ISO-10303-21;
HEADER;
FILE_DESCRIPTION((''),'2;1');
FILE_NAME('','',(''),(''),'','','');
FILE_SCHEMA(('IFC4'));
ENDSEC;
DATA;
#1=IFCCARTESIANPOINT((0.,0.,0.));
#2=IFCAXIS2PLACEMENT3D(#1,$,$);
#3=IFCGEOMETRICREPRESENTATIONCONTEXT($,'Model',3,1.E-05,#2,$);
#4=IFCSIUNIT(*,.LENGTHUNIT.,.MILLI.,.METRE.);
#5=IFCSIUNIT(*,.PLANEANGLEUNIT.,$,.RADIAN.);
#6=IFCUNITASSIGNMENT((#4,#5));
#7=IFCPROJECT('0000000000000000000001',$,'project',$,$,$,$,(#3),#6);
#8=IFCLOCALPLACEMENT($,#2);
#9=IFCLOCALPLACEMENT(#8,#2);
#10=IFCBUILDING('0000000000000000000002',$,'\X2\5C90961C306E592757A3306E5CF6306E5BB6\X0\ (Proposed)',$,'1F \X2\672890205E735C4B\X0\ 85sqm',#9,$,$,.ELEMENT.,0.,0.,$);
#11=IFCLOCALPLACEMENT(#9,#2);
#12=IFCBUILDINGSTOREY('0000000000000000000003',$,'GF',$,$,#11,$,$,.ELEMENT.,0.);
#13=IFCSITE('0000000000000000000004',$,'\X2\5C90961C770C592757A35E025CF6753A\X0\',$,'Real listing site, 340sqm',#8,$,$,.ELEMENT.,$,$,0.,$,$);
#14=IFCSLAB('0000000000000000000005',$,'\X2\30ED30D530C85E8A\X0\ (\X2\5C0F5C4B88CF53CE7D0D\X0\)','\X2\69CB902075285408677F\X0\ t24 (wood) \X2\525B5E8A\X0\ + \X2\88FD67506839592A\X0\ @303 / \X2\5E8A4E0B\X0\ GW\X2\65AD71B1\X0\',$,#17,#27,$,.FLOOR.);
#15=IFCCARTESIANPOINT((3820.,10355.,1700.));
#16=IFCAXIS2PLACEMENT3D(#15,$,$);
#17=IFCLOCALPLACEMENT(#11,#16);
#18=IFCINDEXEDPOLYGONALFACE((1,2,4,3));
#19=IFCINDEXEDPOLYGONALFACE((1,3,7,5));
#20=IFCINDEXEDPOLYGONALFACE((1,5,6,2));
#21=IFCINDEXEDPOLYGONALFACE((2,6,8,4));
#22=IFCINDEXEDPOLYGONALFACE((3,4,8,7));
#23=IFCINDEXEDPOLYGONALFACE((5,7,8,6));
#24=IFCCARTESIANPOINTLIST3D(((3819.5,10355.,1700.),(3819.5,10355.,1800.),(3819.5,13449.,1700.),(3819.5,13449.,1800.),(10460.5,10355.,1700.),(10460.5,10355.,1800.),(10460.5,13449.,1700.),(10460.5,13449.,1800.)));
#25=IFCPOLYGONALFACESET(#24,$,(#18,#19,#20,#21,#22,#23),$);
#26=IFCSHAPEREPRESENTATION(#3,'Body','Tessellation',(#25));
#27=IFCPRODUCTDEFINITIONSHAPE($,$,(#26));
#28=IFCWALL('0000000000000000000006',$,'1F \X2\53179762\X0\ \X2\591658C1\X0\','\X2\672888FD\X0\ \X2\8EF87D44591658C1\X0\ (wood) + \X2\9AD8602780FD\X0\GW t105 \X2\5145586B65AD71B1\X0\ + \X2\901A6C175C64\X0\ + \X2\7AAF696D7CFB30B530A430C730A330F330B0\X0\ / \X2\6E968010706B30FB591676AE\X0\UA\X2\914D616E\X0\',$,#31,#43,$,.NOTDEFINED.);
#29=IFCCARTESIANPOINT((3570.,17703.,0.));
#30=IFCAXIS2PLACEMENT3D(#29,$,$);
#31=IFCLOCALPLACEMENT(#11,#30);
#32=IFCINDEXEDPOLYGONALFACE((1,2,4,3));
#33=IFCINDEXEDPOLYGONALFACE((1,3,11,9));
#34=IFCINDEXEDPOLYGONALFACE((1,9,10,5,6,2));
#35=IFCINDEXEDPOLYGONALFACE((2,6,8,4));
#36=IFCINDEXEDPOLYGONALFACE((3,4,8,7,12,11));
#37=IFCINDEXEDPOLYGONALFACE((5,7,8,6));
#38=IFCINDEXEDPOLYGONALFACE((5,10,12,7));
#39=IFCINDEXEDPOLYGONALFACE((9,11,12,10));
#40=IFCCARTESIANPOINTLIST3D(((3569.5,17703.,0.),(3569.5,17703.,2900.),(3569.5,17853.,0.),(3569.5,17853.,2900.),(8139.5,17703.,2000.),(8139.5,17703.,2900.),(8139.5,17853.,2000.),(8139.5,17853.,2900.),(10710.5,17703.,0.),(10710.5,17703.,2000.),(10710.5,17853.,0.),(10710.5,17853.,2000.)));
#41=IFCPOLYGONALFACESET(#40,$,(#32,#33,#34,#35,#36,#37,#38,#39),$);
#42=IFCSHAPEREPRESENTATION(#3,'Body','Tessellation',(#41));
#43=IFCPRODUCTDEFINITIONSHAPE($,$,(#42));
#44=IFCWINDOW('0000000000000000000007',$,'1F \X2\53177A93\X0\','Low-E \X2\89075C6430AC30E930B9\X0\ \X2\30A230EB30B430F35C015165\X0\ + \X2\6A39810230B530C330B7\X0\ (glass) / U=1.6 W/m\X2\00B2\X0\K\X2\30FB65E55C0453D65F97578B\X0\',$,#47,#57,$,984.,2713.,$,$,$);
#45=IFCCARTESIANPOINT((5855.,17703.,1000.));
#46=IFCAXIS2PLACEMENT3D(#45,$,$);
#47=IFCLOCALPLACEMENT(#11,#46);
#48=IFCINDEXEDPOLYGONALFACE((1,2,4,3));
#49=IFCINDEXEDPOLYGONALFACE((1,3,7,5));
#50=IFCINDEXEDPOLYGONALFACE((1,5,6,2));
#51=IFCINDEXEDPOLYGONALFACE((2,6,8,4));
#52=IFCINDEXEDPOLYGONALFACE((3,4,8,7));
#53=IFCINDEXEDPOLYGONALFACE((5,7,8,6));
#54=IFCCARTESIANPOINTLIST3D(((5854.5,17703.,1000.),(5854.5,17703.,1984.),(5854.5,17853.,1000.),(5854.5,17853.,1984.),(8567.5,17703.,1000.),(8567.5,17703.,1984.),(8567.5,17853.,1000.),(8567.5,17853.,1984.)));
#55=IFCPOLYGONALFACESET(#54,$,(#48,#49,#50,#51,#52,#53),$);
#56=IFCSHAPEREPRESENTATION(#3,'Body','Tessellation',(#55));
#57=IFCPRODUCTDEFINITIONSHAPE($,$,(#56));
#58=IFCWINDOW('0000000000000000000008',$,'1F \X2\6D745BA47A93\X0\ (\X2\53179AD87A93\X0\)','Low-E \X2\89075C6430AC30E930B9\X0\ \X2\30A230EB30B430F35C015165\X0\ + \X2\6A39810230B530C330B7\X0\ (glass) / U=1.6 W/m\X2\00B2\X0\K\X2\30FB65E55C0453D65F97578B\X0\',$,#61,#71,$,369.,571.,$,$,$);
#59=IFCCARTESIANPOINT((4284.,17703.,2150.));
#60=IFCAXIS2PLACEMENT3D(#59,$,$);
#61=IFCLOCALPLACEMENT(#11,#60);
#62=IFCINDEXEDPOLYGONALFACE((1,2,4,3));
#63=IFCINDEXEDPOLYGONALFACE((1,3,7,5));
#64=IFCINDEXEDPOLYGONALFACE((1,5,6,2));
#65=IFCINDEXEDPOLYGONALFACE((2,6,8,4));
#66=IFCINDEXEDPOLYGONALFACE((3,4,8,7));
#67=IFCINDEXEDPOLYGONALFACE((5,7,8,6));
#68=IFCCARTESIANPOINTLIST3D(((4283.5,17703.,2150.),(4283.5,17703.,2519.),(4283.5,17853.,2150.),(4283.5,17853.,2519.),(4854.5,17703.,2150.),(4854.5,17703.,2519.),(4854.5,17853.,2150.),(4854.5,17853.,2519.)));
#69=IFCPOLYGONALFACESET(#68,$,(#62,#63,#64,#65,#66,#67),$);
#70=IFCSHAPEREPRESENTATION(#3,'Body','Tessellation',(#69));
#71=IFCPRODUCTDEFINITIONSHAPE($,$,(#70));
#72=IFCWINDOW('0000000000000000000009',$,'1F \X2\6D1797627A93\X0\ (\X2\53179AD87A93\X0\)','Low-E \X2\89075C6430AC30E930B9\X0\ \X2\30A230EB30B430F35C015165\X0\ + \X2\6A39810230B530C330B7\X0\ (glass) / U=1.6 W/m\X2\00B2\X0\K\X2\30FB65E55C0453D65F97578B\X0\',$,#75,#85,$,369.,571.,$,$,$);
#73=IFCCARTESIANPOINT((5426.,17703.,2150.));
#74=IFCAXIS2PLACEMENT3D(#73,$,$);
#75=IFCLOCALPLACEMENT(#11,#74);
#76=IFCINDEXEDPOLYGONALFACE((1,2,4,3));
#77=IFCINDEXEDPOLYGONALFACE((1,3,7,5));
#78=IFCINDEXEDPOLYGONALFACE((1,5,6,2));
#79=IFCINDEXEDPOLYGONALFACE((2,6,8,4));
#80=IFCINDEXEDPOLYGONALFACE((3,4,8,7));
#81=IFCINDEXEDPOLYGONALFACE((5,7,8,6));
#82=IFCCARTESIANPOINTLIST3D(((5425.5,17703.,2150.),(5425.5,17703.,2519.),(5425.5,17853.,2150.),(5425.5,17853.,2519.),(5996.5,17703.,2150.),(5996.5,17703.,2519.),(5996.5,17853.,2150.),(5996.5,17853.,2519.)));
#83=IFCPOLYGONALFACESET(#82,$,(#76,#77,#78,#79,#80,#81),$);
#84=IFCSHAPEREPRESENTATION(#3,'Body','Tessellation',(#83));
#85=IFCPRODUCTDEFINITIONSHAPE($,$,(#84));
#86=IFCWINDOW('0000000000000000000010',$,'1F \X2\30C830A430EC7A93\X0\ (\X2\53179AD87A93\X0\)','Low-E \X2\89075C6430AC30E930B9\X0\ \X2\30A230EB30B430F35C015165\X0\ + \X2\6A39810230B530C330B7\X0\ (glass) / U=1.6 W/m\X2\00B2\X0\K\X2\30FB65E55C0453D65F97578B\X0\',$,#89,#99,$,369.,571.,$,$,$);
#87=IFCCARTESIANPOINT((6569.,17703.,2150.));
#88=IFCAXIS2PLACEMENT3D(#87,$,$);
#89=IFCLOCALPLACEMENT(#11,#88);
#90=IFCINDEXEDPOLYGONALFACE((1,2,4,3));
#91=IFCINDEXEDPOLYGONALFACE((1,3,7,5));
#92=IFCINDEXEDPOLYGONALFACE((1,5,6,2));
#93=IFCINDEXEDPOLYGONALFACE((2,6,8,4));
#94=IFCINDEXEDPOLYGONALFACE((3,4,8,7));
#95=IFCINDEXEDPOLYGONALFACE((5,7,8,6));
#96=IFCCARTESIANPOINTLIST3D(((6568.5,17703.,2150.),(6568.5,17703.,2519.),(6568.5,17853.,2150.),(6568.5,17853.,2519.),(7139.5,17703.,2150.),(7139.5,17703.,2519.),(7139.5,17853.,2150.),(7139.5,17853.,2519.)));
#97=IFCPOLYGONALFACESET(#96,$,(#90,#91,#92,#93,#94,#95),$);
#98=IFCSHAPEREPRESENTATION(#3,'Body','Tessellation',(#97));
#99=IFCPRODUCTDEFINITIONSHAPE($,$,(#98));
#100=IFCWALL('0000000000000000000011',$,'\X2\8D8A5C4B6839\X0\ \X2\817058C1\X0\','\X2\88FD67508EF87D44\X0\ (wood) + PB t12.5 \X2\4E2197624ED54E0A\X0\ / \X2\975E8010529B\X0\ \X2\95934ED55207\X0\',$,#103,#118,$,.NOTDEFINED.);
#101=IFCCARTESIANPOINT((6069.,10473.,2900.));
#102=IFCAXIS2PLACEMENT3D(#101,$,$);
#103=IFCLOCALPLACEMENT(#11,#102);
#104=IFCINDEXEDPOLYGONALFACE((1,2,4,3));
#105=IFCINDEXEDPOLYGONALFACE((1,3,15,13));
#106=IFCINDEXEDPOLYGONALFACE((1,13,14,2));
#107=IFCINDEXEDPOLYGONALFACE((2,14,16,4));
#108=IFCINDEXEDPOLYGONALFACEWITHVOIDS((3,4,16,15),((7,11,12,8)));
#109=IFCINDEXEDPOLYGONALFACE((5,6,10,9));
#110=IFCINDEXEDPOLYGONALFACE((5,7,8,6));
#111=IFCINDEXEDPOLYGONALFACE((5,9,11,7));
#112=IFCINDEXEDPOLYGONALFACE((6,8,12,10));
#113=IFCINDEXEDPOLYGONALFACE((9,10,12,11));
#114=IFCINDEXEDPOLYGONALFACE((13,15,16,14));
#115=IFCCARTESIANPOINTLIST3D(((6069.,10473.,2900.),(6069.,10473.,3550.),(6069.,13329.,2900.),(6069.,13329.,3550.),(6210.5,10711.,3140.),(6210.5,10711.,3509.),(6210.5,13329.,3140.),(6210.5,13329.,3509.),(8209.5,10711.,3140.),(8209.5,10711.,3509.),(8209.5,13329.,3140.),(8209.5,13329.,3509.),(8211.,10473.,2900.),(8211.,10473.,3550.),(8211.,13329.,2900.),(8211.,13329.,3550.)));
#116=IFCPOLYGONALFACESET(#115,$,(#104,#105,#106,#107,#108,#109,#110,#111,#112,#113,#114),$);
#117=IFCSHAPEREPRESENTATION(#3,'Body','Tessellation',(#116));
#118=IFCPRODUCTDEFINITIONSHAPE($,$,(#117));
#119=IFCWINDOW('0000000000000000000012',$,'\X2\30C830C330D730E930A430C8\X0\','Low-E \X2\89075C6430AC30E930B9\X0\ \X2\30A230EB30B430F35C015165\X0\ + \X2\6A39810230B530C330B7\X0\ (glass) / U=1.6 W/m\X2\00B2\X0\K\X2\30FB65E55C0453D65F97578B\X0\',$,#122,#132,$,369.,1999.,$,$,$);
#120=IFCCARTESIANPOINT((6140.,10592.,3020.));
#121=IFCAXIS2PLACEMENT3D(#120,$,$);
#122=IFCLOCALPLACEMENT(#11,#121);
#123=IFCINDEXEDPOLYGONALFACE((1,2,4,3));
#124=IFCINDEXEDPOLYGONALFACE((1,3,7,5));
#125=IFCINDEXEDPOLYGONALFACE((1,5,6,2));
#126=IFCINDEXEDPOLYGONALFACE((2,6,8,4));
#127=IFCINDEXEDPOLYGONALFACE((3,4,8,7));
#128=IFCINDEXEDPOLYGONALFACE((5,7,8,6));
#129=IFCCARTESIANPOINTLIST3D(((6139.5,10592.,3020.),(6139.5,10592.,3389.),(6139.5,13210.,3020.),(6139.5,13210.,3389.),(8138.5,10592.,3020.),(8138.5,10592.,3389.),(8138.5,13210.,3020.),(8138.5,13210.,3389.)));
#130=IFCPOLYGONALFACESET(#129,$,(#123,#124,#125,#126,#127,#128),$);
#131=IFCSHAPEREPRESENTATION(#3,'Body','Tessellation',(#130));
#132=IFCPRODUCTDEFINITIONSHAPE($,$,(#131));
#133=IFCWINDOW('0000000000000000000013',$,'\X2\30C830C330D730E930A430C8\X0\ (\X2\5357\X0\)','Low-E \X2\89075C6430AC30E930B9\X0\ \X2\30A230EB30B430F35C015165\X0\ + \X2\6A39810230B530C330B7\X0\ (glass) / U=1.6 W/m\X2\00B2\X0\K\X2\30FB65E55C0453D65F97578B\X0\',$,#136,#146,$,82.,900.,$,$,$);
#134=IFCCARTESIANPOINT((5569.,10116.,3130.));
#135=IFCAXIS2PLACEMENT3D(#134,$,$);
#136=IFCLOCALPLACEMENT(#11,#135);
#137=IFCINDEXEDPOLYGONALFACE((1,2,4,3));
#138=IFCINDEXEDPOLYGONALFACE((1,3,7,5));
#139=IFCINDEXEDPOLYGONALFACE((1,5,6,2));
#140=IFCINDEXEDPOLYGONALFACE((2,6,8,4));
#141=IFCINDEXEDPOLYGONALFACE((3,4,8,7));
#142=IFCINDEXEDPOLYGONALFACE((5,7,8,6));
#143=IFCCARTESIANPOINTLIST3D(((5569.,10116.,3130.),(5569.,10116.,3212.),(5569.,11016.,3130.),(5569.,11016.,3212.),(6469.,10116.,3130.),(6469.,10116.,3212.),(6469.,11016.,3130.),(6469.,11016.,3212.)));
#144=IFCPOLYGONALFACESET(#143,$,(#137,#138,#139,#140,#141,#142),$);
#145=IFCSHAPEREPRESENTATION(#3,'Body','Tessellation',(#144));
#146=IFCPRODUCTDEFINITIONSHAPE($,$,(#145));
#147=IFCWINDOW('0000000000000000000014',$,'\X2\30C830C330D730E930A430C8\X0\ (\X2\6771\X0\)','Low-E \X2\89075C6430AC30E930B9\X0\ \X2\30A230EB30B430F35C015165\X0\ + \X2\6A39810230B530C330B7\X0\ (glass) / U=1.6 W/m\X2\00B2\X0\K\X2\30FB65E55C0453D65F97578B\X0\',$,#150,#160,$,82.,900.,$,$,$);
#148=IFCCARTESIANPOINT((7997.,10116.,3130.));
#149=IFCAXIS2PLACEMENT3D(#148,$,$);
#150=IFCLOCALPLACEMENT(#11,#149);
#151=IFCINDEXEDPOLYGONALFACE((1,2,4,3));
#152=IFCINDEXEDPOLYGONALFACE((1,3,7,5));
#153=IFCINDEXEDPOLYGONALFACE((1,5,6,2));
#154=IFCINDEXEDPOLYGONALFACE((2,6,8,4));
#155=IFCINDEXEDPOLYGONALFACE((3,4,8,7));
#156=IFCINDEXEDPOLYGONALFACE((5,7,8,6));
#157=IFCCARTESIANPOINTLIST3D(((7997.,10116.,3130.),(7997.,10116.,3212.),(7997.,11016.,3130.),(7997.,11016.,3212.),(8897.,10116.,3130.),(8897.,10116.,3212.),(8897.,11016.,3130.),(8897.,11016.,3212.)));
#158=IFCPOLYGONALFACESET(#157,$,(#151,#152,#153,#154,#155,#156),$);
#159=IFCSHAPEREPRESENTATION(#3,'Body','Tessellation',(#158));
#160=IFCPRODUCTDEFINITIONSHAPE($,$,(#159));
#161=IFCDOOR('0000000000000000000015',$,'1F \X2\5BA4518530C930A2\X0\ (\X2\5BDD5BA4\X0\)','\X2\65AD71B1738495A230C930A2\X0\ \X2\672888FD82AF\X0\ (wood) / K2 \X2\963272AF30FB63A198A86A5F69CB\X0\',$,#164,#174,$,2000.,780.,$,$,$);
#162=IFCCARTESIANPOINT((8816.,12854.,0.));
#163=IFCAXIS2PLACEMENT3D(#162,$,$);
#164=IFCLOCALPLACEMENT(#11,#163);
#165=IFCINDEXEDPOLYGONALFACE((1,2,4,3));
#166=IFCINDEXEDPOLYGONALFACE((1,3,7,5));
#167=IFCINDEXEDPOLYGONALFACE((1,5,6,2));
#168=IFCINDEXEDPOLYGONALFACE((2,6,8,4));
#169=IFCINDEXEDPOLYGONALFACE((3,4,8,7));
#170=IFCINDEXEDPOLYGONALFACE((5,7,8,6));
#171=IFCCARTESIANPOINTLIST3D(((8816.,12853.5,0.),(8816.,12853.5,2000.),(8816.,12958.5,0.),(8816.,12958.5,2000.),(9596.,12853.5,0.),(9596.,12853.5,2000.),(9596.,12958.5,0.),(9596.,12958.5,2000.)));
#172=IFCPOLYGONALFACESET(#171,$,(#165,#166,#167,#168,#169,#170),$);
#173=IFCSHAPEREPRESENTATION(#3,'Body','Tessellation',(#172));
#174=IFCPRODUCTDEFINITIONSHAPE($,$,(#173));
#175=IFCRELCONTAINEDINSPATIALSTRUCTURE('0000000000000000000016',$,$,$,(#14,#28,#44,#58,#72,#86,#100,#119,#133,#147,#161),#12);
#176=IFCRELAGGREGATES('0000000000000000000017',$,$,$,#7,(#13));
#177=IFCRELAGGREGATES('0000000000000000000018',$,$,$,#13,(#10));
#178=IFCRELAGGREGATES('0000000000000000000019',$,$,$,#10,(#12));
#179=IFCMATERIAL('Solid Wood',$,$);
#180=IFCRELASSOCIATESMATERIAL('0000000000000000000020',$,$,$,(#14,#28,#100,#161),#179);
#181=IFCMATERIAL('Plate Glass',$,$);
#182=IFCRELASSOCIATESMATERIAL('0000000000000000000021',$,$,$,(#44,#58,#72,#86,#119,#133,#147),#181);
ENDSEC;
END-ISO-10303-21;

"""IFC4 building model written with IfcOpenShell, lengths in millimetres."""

from ifc_helpers import new_model, si_unit, frame, frame_2d, origin, place, context, project, spatial, rectangle, extrude, material, element, fill, save


model = new_model("IFC4")

# Units and contexts
model_context = context("Model", 3, precision=1e-05, world=origin())
ifc_project = project(units=[si_unit("LENGTHUNIT", "METRE", prefix="MILLI"), si_unit("PLANEANGLEUNIT", "RADIAN")], contexts=[model_context])

# Site, building, storey
site_placement = place(None, origin())
site = spatial("IfcSite", under=ifc_project, at=site_placement, Name="岐阜県大垣市島町", ObjectType="Real listing site, 340sqm", CompositionType="ELEMENT", RefElevation=0.0)
building_placement = place(site_placement, origin())
building = spatial("IfcBuilding", under=site, at=building_placement, Name="岐阜の大垣の島の家 (Proposed)", ObjectType="1F 木造平屋 85sqm", CompositionType="ELEMENT", ElevationOfRefHeight=0.0, ElevationOfTerrain=0.0)
storey_placement = place(building_placement, origin())
storey = spatial("IfcBuildingStorey", under=building, at=storey_placement, Name="GF", CompositionType="ELEMENT", Elevation=0.0)

# Slab
ifc_material_1 = material(Name="Solid Wood")
slab_placement = place(storey_placement, frame((3820.0, 10355.0, 1700.0)))
element("IfcSlab", 1, at=slab_placement, inside=storey, material=ifc_material_1, Name="ロフト床 (小屋裏収納)", Description="構造用合板 t24 (wood) 剛床 + 製材根太 @303 / 床下 GW断熱", PredefinedType="FLOOR", context=model_context, shape_type="SweptSolid", body=[
    extrude(rectangle(XDim=6641.0, YDim=3094.0, at=frame_2d((3320.0, 1547.0))), frame((3820.0, 10355.0, 1700.0)), (0.0, 0.0, 1.0), 100.0),
])

# Wall, openings, windows
wall_1_placement = place(storey_placement, frame((3570.0, 17703.0, 0.0)))
wall_1 = element("IfcWall", 2, at=wall_1_placement, inside=storey, material=ifc_material_1, Name="1F 北面 外壁", Description="木製 軸組外壁 (wood) + 高性能GW t105 充填断熱 + 通気層 + 窯業系サイディング / 準耐火・外皮UA配慮", PredefinedType="NOTDEFINED", context=model_context, shape_type="SweptSolid", body=[
    extrude(rectangle(XDim=7141.0, YDim=150.0, at=frame_2d((3570.0, 75.0))), frame((3570.0, 17703.0, 0.0)), (0.0, 0.0, 1.0), 2900.0),
])
opening_1_placement = place(storey_placement, frame((5855.0, 17703.0, 1000.0)))
opening_1 = element("IfcOpeningElement", 3, at=opening_1_placement, cuts=wall_1, PredefinedType="NOTDEFINED", context=model_context, shape_type="SweptSolid", body=[
    extrude(rectangle(XDim=2713.0, YDim=150.0, at=frame_2d((1356.0, 75.0))), frame((5855.0, 17703.0, 1000.0)), (0.0, 0.0, 1.0), 984.0),
])
opening_2_placement = place(storey_placement, frame((4284.0, 17703.0, 2150.0)))
opening_2 = element("IfcOpeningElement", 4, at=opening_2_placement, cuts=wall_1, PredefinedType="NOTDEFINED", context=model_context, shape_type="SweptSolid", body=[
    extrude(rectangle(XDim=571.0, YDim=150.0, at=frame_2d((285.0, 75.0))), frame((4284.0, 17703.0, 2150.0)), (0.0, 0.0, 1.0), 369.0),
])
opening_3_placement = place(storey_placement, frame((5426.0, 17703.0, 2150.0)))
opening_3 = element("IfcOpeningElement", 5, at=opening_3_placement, cuts=wall_1, PredefinedType="NOTDEFINED", context=model_context, shape_type="SweptSolid", body=[
    extrude(rectangle(XDim=571.0, YDim=150.0, at=frame_2d((285.0, 75.0))), frame((5426.0, 17703.0, 2150.0)), (0.0, 0.0, 1.0), 369.0),
])
opening_4_placement = place(storey_placement, frame((6569.0, 17703.0, 2150.0)))
opening_4 = element("IfcOpeningElement", 6, at=opening_4_placement, cuts=wall_1, PredefinedType="NOTDEFINED", context=model_context, shape_type="SweptSolid", body=[
    extrude(rectangle(XDim=571.0, YDim=150.0, at=frame_2d((285.0, 75.0))), frame((6569.0, 17703.0, 2150.0)), (0.0, 0.0, 1.0), 369.0),
])
ifc_material_2 = material(Name="Plate Glass")
window_1_placement = place(storey_placement, frame((5855.0, 17703.0, 1000.0)))
window_1 = element("IfcWindow", 7, at=window_1_placement, inside=storey, material=ifc_material_2, Name="1F 北窓", Description="Low-E 複層ガラス アルゴン封入 + 樹脂サッシ (glass) / U=1.6 W/m²K・日射取得型", OverallHeight=984.0, OverallWidth=2713.0, context=model_context, shape_type="SweptSolid", body=[
    extrude(rectangle(XDim=2713.0, YDim=150.0, at=frame_2d((1356.0, 75.0))), frame((5855.0, 17703.0, 1000.0)), (0.0, 0.0, 1.0), 984.0),
])
fill(opening_1, window_1)
window_2_placement = place(storey_placement, frame((4284.0, 17703.0, 2150.0)))
window_2 = element("IfcWindow", 8, at=window_2_placement, inside=storey, material=ifc_material_2, Name="1F 浴室窓 (北高窓)", Description="Low-E 複層ガラス アルゴン封入 + 樹脂サッシ (glass) / U=1.6 W/m²K・日射取得型", OverallHeight=369.0, OverallWidth=571.0, context=model_context, shape_type="SweptSolid", body=[
    extrude(rectangle(XDim=571.0, YDim=150.0, at=frame_2d((285.0, 75.0))), frame((4284.0, 17703.0, 2150.0)), (0.0, 0.0, 1.0), 369.0),
])
fill(opening_2, window_2)
window_3_placement = place(storey_placement, frame((5426.0, 17703.0, 2150.0)))
window_3 = element("IfcWindow", 9, at=window_3_placement, inside=storey, material=ifc_material_2, Name="1F 洗面窓 (北高窓)", Description="Low-E 複層ガラス アルゴン封入 + 樹脂サッシ (glass) / U=1.6 W/m²K・日射取得型", OverallHeight=369.0, OverallWidth=571.0, context=model_context, shape_type="SweptSolid", body=[
    extrude(rectangle(XDim=571.0, YDim=150.0, at=frame_2d((285.0, 75.0))), frame((5426.0, 17703.0, 2150.0)), (0.0, 0.0, 1.0), 369.0),
])
fill(opening_3, window_3)
window_4_placement = place(storey_placement, frame((6569.0, 17703.0, 2150.0)))
window_4 = element("IfcWindow", 10, at=window_4_placement, inside=storey, material=ifc_material_2, Name="1F トイレ窓 (北高窓)", Description="Low-E 複層ガラス アルゴン封入 + 樹脂サッシ (glass) / U=1.6 W/m²K・日射取得型", OverallHeight=369.0, OverallWidth=571.0, context=model_context, shape_type="SweptSolid", body=[
    extrude(rectangle(XDim=571.0, YDim=150.0, at=frame_2d((285.0, 75.0))), frame((6569.0, 17703.0, 2150.0)), (0.0, 0.0, 1.0), 369.0),
])
fill(opening_4, window_4)

# Wall, openings, windows
wall_2_placement = place(storey_placement, frame((6069.0, 10473.0, 2900.0)))
wall_2 = element("IfcWall", 11, at=wall_2_placement, inside=storey, material=ifc_material_1, Name="越屋根 腰壁", Description="製材軸組 (wood) + PB t12.5 両面仕上 / 非耐力 間仕切", PredefinedType="NOTDEFINED", context=model_context, shape_type="SweptSolid", body=[
    extrude(rectangle(XDim=2142.0, YDim=2856.0, at=frame_2d((1071.0, 1428.0))), frame((6069.0, 10473.0, 2900.0)), (0.0, 0.0, 1.0), 650.0),
])
opening_5_placement = place(storey_placement, frame((6140.0, 10592.0, 3020.0)))
opening_5 = element("IfcOpeningElement", 12, at=opening_5_placement, cuts=wall_2, PredefinedType="NOTDEFINED", context=model_context, shape_type="SweptSolid", body=[
    extrude(rectangle(XDim=1999.0, YDim=2618.0, at=frame_2d((999.0, 1309.0))), frame((6140.0, 10592.0, 3020.0)), (0.0, 0.0, 1.0), 369.0),
])
opening_6_placement = place(storey_placement, frame((5569.0, 10116.0, 3130.0)))
opening_6 = element("IfcOpeningElement", 13, at=opening_6_placement, cuts=wall_2, PredefinedType="NOTDEFINED", context=model_context, shape_type="SweptSolid", body=[
    extrude(rectangle(XDim=900.0, YDim=900.0, at=frame_2d((450.0, 450.0))), frame((5569.0, 10116.0, 3130.0)), (0.0, 0.0, 1.0), 82.0),
])
opening_7_placement = place(storey_placement, frame((7997.0, 10116.0, 3130.0)))
opening_7 = element("IfcOpeningElement", 14, at=opening_7_placement, cuts=wall_2, PredefinedType="NOTDEFINED", context=model_context, shape_type="SweptSolid", body=[
    extrude(rectangle(XDim=900.0, YDim=900.0, at=frame_2d((450.0, 450.0))), frame((7997.0, 10116.0, 3130.0)), (0.0, 0.0, 1.0), 82.0),
])
window_5_placement = place(storey_placement, frame((6140.0, 10592.0, 3020.0)))
window_5 = element("IfcWindow", 15, at=window_5_placement, inside=storey, material=ifc_material_2, Name="トップライト", Description="Low-E 複層ガラス アルゴン封入 + 樹脂サッシ (glass) / U=1.6 W/m²K・日射取得型", OverallHeight=369.0, OverallWidth=1999.0, context=model_context, shape_type="SweptSolid", body=[
    extrude(rectangle(XDim=1999.0, YDim=2618.0, at=frame_2d((999.0, 1309.0))), frame((6140.0, 10592.0, 3020.0)), (0.0, 0.0, 1.0), 369.0),
])
fill(opening_5, window_5)
window_6_placement = place(storey_placement, frame((5569.0, 10116.0, 3130.0)))
window_6 = element("IfcWindow", 16, at=window_6_placement, inside=storey, material=ifc_material_2, Name="トップライト (南)", Description="Low-E 複層ガラス アルゴン封入 + 樹脂サッシ (glass) / U=1.6 W/m²K・日射取得型", OverallHeight=82.0, OverallWidth=900.0, context=model_context, shape_type="SweptSolid", body=[
    extrude(rectangle(XDim=900.0, YDim=900.0, at=frame_2d((450.0, 450.0))), frame((5569.0, 10116.0, 3130.0)), (0.0, 0.0, 1.0), 82.0),
])
fill(opening_6, window_6)
window_7_placement = place(storey_placement, frame((7997.0, 10116.0, 3130.0)))
window_7 = element("IfcWindow", 17, at=window_7_placement, inside=storey, material=ifc_material_2, Name="トップライト (東)", Description="Low-E 複層ガラス アルゴン封入 + 樹脂サッシ (glass) / U=1.6 W/m²K・日射取得型", OverallHeight=82.0, OverallWidth=900.0, context=model_context, shape_type="SweptSolid", body=[
    extrude(rectangle(XDim=900.0, YDim=900.0, at=frame_2d((450.0, 450.0))), frame((7997.0, 10116.0, 3130.0)), (0.0, 0.0, 1.0), 82.0),
])
fill(opening_7, window_7)

# Door
door_1_placement = place(storey_placement, frame((8816.0, 12854.0, 0.0)))
element("IfcDoor", 18, at=door_1_placement, inside=storey, material=ifc_material_1, Name="1F 室内ドア (寝室)", Description="断熱玄関ドア 木製芯 (wood) / K2 防犯・採風機構", OverallHeight=2000.0, OverallWidth=780.0, context=model_context, shape_type="SweptSolid", body=[
    extrude(rectangle(XDim=780.0, YDim=105.0, at=frame_2d((390.0, 52.0))), frame((8816.0, 12854.0, 0.0)), (0.0, 0.0, 1.0), 2000.0),
])

save(model, "model.ifc")
